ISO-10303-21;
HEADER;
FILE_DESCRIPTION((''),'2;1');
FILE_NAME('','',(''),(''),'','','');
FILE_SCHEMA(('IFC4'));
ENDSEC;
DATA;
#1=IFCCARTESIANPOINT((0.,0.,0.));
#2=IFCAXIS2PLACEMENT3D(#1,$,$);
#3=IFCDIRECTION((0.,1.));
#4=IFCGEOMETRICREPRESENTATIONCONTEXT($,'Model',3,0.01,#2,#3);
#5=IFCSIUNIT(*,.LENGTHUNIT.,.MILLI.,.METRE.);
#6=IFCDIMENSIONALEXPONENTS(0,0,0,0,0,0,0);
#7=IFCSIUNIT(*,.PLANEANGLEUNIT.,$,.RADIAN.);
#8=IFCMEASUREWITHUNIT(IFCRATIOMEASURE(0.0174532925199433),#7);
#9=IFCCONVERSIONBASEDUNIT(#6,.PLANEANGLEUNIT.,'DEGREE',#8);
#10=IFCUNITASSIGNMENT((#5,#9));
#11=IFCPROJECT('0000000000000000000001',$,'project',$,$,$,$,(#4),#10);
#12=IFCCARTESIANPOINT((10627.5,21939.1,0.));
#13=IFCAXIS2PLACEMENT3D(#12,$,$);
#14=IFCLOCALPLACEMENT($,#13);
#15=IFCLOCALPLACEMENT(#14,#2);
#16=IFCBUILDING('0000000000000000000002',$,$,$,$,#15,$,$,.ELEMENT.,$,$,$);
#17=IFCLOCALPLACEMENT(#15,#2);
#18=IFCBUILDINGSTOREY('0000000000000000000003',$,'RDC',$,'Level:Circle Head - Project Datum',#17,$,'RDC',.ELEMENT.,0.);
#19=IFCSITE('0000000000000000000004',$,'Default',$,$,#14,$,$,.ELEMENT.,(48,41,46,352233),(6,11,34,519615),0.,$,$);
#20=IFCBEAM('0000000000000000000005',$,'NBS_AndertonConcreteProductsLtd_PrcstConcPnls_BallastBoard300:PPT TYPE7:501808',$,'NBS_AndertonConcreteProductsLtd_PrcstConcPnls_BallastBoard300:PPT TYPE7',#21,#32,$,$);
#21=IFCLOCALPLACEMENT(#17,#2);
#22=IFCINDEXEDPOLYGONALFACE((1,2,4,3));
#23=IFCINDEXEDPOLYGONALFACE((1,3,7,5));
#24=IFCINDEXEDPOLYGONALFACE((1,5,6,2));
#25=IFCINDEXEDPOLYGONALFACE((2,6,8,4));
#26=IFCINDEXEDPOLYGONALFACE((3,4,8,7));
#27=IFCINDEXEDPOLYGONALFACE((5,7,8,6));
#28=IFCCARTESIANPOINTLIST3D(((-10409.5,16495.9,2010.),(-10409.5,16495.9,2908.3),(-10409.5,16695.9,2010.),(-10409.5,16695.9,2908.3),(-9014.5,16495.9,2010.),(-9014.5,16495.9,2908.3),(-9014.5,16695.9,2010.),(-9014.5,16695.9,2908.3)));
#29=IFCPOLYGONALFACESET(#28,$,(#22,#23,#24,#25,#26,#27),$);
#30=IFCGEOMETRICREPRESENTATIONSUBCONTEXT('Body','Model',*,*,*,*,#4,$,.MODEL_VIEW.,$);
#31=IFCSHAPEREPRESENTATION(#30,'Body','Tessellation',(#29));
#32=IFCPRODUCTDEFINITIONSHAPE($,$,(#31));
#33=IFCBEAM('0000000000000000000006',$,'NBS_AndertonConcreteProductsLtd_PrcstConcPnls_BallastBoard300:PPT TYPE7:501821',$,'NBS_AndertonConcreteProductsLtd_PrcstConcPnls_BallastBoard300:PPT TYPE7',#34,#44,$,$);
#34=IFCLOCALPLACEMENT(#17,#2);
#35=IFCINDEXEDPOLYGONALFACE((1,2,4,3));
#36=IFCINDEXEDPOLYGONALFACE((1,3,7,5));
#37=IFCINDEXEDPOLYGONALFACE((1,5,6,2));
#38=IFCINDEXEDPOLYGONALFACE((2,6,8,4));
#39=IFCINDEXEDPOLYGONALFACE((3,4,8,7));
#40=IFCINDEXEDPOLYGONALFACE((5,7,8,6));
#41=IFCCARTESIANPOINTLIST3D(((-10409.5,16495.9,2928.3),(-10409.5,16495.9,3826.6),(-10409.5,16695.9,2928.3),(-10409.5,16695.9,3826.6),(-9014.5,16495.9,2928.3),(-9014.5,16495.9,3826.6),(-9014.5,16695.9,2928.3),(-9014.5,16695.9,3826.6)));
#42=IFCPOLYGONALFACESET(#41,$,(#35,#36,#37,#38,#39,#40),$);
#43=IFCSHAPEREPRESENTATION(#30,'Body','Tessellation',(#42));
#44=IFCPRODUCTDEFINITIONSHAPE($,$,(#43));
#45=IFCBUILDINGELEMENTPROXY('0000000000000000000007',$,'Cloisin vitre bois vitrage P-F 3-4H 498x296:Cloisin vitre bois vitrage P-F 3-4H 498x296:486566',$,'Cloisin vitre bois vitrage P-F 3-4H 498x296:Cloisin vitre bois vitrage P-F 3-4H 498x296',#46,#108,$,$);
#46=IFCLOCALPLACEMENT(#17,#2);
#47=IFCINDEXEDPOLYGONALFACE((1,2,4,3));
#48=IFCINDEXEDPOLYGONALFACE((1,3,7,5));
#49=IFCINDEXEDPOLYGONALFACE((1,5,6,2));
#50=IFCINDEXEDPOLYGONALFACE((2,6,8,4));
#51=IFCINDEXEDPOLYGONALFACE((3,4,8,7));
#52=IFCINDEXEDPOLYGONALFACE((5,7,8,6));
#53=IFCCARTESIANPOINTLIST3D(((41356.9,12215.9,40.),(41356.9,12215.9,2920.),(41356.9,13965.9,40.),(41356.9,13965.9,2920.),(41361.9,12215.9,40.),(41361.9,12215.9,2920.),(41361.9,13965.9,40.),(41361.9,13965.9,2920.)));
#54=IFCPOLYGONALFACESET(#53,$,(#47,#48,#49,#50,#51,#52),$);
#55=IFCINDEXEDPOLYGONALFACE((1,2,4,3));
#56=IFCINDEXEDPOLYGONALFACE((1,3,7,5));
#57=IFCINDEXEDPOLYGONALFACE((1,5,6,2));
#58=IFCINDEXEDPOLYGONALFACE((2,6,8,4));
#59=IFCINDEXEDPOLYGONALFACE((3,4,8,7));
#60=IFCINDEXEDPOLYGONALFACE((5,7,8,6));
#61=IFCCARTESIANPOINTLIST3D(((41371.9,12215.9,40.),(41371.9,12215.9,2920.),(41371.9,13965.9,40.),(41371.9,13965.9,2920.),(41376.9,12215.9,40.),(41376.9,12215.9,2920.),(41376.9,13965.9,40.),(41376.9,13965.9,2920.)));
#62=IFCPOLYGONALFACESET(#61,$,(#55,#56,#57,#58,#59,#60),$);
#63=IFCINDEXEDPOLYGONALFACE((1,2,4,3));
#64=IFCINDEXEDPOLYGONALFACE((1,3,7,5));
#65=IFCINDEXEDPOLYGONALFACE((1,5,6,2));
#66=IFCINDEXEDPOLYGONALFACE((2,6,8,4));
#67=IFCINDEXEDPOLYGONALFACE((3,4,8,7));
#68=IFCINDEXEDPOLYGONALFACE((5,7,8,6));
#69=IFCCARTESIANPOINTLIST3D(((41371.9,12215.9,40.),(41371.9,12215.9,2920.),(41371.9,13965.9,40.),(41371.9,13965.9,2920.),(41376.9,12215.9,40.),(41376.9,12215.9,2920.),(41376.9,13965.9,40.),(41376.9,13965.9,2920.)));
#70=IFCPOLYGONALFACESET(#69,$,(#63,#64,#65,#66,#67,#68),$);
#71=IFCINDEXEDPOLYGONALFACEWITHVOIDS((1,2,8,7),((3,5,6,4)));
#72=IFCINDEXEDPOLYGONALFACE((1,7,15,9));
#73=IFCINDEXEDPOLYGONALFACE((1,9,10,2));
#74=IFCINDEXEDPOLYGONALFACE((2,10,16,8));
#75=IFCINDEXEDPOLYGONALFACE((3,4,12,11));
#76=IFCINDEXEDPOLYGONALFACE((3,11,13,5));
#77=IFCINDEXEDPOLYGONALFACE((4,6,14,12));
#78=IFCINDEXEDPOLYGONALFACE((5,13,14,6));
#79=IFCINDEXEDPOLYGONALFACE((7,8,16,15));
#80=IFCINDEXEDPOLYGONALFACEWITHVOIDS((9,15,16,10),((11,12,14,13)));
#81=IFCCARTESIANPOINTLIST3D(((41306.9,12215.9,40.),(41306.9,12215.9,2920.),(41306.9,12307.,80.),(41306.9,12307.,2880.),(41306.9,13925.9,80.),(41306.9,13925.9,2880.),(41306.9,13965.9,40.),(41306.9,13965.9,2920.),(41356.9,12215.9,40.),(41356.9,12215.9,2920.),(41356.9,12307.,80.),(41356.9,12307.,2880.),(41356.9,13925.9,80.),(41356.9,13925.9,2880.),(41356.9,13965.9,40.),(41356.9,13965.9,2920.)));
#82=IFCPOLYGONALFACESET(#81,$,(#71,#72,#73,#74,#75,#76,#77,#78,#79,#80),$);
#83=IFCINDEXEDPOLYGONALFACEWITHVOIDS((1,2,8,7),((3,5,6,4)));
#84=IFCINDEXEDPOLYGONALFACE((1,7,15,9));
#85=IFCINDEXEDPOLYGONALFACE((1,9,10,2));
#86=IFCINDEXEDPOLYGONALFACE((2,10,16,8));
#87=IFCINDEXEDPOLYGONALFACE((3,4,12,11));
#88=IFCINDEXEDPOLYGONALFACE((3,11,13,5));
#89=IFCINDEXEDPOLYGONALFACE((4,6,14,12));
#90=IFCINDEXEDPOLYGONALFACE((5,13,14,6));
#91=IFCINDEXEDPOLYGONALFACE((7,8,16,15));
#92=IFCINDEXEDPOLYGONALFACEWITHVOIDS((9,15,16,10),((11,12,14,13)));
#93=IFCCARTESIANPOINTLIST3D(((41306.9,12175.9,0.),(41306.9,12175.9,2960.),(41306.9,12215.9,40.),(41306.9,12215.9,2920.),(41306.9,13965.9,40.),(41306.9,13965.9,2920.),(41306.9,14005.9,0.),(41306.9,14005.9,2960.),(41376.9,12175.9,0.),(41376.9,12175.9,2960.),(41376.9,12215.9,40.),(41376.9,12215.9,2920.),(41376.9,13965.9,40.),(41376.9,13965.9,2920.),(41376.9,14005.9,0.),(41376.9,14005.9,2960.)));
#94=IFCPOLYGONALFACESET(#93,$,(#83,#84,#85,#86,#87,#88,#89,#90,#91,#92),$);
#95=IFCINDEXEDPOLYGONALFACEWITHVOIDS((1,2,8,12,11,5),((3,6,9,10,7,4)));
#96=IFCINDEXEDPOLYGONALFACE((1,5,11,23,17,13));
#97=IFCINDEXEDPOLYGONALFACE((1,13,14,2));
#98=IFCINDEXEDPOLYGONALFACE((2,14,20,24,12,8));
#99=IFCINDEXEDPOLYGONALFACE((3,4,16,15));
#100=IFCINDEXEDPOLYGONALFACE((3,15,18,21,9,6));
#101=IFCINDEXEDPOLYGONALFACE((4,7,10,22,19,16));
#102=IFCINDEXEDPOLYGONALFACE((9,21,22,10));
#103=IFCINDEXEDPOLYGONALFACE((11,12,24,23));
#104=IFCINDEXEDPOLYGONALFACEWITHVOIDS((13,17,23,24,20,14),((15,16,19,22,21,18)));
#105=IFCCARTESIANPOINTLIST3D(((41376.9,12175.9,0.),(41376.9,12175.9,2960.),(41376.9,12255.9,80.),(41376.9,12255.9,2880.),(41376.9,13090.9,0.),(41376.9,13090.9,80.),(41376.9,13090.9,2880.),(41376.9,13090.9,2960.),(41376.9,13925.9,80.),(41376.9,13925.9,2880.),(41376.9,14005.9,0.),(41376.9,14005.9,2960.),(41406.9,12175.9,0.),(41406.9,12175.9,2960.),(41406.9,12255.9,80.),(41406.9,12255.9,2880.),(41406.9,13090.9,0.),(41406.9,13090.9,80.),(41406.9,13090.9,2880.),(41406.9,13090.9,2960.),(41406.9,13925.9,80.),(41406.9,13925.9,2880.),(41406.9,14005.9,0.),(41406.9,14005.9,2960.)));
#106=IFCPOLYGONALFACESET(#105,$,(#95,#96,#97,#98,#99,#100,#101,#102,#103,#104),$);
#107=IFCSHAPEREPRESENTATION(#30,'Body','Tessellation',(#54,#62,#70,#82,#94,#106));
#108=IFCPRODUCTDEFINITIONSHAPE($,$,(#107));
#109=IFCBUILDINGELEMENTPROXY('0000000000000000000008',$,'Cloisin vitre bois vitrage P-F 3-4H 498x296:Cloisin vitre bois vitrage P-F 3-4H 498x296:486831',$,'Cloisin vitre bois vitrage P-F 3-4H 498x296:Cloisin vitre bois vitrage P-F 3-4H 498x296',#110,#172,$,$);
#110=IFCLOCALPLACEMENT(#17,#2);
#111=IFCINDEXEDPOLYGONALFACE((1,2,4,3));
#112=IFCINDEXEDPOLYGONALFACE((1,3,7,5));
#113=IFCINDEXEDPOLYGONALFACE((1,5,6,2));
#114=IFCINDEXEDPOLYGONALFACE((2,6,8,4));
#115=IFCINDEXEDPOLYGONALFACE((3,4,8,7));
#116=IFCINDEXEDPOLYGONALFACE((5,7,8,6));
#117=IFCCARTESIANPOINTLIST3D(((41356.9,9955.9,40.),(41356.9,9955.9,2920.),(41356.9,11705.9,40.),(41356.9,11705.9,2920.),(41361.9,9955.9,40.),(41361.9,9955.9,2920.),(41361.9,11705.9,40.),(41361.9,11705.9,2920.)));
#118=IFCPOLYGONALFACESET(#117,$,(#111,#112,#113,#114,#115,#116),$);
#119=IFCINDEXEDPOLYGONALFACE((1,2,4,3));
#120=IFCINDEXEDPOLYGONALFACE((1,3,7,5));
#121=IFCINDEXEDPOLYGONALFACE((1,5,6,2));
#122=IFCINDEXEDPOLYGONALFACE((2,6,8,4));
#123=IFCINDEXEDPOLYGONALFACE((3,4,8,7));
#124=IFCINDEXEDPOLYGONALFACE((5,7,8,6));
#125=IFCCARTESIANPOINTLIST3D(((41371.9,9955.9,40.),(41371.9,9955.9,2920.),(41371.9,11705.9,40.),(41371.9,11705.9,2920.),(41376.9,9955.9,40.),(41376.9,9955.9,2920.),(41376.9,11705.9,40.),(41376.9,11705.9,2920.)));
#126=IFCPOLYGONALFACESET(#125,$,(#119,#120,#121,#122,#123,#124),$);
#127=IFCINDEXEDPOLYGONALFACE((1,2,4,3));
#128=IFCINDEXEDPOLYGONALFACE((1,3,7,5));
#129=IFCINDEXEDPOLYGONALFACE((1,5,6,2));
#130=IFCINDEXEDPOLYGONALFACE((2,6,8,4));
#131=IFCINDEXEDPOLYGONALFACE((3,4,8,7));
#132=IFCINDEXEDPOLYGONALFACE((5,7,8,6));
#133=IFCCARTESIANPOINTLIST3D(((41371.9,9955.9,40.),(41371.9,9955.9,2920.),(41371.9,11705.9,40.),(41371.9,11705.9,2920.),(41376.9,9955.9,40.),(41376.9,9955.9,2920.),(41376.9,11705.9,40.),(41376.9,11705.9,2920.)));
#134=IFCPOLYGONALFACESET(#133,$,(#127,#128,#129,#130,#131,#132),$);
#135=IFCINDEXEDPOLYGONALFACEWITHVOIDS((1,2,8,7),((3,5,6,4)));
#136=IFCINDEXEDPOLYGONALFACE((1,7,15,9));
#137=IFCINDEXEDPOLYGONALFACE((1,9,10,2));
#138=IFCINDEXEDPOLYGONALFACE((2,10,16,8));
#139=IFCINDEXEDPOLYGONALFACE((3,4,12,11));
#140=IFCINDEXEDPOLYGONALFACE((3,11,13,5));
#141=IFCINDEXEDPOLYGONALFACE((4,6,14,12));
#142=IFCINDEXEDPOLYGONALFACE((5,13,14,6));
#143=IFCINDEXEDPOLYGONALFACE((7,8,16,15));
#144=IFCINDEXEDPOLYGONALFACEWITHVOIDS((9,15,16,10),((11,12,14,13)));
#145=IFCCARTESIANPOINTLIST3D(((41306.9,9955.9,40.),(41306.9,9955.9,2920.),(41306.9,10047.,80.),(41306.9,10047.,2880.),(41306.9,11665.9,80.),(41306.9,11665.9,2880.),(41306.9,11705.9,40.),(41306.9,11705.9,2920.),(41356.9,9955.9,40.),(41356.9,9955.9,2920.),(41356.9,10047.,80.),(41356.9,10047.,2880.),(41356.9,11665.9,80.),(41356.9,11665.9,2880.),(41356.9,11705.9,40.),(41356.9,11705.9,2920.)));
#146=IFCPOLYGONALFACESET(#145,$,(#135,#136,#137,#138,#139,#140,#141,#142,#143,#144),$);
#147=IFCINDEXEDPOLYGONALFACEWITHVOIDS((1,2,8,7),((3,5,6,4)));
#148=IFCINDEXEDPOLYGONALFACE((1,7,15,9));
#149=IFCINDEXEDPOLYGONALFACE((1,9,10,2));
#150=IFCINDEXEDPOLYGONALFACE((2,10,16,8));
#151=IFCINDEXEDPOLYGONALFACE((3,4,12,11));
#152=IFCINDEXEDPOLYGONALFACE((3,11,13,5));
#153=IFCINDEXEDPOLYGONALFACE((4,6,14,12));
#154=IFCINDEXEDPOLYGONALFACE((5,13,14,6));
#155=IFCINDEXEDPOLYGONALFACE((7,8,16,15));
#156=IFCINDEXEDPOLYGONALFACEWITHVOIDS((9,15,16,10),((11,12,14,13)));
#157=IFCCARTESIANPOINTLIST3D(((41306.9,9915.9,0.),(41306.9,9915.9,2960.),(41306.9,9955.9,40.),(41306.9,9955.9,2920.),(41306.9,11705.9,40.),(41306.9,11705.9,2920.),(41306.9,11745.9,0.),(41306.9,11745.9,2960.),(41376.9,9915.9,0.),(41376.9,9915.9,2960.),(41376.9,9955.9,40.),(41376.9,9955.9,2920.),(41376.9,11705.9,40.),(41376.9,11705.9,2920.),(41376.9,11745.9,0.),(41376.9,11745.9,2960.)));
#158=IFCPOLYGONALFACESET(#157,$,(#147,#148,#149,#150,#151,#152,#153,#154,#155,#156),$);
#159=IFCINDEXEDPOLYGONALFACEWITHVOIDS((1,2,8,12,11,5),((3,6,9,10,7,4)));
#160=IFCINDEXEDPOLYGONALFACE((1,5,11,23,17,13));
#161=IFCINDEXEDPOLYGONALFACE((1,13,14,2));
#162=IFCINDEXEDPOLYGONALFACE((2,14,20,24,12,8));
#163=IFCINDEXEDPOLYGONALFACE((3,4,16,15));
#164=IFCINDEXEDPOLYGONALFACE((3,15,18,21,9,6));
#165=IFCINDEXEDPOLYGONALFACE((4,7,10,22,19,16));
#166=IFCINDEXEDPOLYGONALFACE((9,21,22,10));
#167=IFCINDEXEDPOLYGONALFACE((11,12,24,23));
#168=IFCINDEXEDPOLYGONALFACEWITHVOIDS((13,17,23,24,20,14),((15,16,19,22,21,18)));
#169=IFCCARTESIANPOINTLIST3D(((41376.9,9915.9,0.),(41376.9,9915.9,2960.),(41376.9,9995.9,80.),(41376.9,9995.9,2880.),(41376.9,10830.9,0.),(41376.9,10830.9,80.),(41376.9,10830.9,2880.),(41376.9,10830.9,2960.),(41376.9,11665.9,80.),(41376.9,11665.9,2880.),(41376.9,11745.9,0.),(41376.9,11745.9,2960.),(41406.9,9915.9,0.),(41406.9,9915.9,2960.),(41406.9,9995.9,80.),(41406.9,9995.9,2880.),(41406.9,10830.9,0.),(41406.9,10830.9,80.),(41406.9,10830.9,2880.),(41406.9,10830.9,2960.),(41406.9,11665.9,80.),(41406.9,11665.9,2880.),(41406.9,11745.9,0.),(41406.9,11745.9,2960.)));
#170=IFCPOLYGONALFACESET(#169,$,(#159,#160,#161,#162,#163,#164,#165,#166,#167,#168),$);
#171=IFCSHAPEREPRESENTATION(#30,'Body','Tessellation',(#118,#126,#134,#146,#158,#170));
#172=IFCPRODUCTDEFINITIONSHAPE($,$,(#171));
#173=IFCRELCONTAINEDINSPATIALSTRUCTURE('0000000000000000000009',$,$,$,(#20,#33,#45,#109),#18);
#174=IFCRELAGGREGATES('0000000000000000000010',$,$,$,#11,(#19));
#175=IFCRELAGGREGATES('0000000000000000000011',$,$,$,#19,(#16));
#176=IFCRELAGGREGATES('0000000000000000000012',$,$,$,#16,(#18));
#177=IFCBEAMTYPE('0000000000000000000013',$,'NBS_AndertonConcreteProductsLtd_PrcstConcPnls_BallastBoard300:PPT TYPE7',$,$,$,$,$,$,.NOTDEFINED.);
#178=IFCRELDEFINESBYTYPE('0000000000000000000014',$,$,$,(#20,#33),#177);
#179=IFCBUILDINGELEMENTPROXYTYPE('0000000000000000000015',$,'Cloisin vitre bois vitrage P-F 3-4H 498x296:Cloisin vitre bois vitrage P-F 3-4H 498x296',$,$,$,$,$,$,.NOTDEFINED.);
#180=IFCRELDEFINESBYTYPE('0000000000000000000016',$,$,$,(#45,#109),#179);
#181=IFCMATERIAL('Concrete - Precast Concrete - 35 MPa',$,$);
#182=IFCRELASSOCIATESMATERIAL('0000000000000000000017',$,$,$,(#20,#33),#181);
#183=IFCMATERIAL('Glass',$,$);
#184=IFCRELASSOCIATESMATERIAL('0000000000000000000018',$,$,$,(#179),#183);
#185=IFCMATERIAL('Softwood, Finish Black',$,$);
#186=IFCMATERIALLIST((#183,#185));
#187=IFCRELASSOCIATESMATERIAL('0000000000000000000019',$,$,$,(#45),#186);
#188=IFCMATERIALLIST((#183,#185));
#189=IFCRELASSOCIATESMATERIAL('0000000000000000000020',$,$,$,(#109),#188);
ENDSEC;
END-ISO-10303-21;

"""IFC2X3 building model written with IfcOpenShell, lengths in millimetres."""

from ifc_helpers import new_model, entity, si_unit, converted_unit, direction, frame, frame_2d, origin, place, context, subcontext, project, spatial, polyline, rectangle, outline, extrude, source, transform, mapped, material, material_list, type_object, type_shapes, element, save


model = new_model("IFC2X3")

# Units and contexts
model_context = context("Model", 3, precision=0.01, world=origin(), true_north=direction((0.0, 1.0)))
body_context = subcontext(model_context, "Body", "Model", "MODEL_VIEW")
ifc_project = project(units=[si_unit("LENGTHUNIT", "METRE", prefix="MILLI"), converted_unit("PLANEANGLEUNIT", "DEGREE", entity("IfcRatioMeasure", 0.0174532925199433), si_unit("PLANEANGLEUNIT", "RADIAN"), dimensions=[0, 0, 0, 0, 0, 0, 0])], contexts=[model_context])

# Site, building, storey
site_placement = place(None, frame((10627.5, 21939.1, 0.0)))
site = spatial("IfcSite", under=ifc_project, at=site_placement, Name="Default", CompositionType="ELEMENT", RefLatitude=(48, 41, 46, 352233), RefLongitude=(6, 11, 34, 519615), RefElevation=0.0)
building_placement = place(site_placement, origin())
building = spatial("IfcBuilding", under=site, at=building_placement, CompositionType="ELEMENT")
storey_placement = place(building_placement, origin())
storey = spatial("IfcBuildingStorey", under=building, at=storey_placement, Name="RDC", ObjectType="Level:Circle Head - Project Datum", LongName="RDC", CompositionType="ELEMENT", Elevation=0.0)

# Beams
ifc_material_1 = material(Name="Concrete - Precast Concrete - 35 MPa")
beam_type = type_object("IfcBeamType", Name="NBS_AndertonConcreteProductsLtd_PrcstConcPnls_BallastBoard300:PPT TYPE7", PredefinedType="NOTDEFINED")
beam_1_placement = place(storey_placement, origin())
element("IfcBeam", 1, at=beam_1_placement, inside=storey, type_object=beam_type, material=ifc_material_1, Name="NBS_AndertonConcreteProductsLtd_PrcstConcPnls_BallastBoard300:PPT TYPE7:501808", ObjectType="NBS_AndertonConcreteProductsLtd_PrcstConcPnls_BallastBoard300:PPT TYPE7", context=body_context, shape_type="SweptSolid", body=[
    extrude(rectangle(XDim=898.3, YDim=200.0, at=frame_2d((0.0, 0.0), x_axis=(0.0, 1.0))), frame((-10409.5, 16595.9, 2459.1), z_axis=(1.0, 0.0, 0.0), x_axis=(0.0, 1.0, 0.0)), (0.0, 0.0, 1.0), 1395.0),
])
beam_2_placement = place(storey_placement, origin())
element("IfcBeam", 2, at=beam_2_placement, inside=storey, type_object=beam_type, material=ifc_material_1, Name="NBS_AndertonConcreteProductsLtd_PrcstConcPnls_BallastBoard300:PPT TYPE7:501821", ObjectType="NBS_AndertonConcreteProductsLtd_PrcstConcPnls_BallastBoard300:PPT TYPE7", context=body_context, shape_type="SweptSolid", body=[
    extrude(rectangle(XDim=898.3, YDim=200.0, at=frame_2d((0.0, 0.0), x_axis=(0.0, 1.0))), frame((-10409.5, 16595.9, 3377.4), z_axis=(1.0, 0.0, 0.0), x_axis=(0.0, 1.0, 0.0)), (0.0, 0.0, 1.0), 1395.0),
])

# Building element proxies
ifc_material_2 = material(Name="Glass")
ifc_material_3 = material(Name="Softwood, Finish Black")
ifc_material_list_1 = material_list([ifc_material_2, ifc_material_3])
building_element_proxy_type_1 = type_object("IfcBuildingElementProxyType", Name="Cloisin vitre bois vitrage P-F 3-4H 498x296:Cloisin vitre bois vitrage P-F 3-4H 498x296", PredefinedType="NOTDEFINED", material=ifc_material_2)
shared_shape_1 = source(origin(), body_context, "Body", "SweptSolid", [
    extrude(rectangle(XDim=5.0, YDim=1750.0, at=frame_2d((0.0, 0.0), x_axis=(1.0, 0.0))), frame((0.0, -47.5, 40.0), z_axis=(0.0, 0.0, 1.0), x_axis=(0.0, 1.0, 0.0)), (0.0, 0.0, 1.0), 2880.0),
    extrude(rectangle(XDim=5.0, YDim=1750.0, at=frame_2d((0.0, 0.0), x_axis=(1.0, 0.0))), frame((0.0, -32.5, 40.0), z_axis=(0.0, 0.0, 1.0), x_axis=(0.0, 1.0, 0.0)), (0.0, 0.0, 1.0), 2880.0),
    extrude(rectangle(XDim=5.0, YDim=1750.0, at=frame_2d((0.0, 0.0), x_axis=(1.0, 0.0))), frame((0.0, -32.5, 40.0), z_axis=(0.0, 0.0, 1.0), x_axis=(0.0, 1.0, 0.0)), (0.0, 0.0, 1.0), 2880.0),
    extrude(outline(polyline([(-1440.0, -875.0), (1440.0, -875.0), (1440.0, 875.0), (-1440.0, 875.0), (-1440.0, -875.0)]), holes=[polyline([(1400.0, 835.0), (1400.0, -783.9), (-1400.0, -783.9), (-1400.0, 835.0), (1400.0, 835.0)])]), frame((0.0, -100.0, 1480.0), z_axis=(0.0, 1.0, 0.0), x_axis=(0.0, 0.0, -1.0)), (0.0, 0.0, 1.0), 50.0),
    extrude(outline(polyline([(-1480.0, -915.0), (1480.0, -915.0), (1480.0, 915.0), (-1480.0, 915.0), (-1480.0, -915.0)]), holes=[polyline([(-1440.0, -875.0), (-1440.0, 875.0), (1440.0, 875.0), (1440.0, -875.0), (-1440.0, -875.0)])]), frame((0.0, -100.0, 1480.0), z_axis=(0.0, 1.0, 0.0), x_axis=(0.0, 0.0, -1.0)), (0.0, 0.0, 1.0), 70.0),
    extrude(outline(polyline([(-1480.0, -915.0), (1480.0, -915.0), (1480.0, 0.0), (1480.0, 915.0), (-1480.0, 915.0), (-1480.0, 0.0), (-1480.0, -915.0)]), holes=[polyline([(1400.0, 0.0), (1400.0, -835.0), (-1400.0, -835.0), (-1400.0, 0.0), (-1400.0, 835.0), (1400.0, 835.0), (1400.0, 0.0)])]), frame((0.0, -30.0, 1480.0), z_axis=(0.0, 1.0, 0.0), x_axis=(0.0, 0.0, 1.0)), (0.0, 0.0, 1.0), 30.0),
])
type_shapes(building_element_proxy_type_1, [shared_shape_1])
proxy_1_placement = place(storey_placement, frame((41406.9, 13090.9, 0.0), z_axis=(0.0, 0.0, 1.0), x_axis=(0.0, -1.0, 0.0)))
element("IfcBuildingElementProxy", 3, at=proxy_1_placement, inside=storey, type_object=building_element_proxy_type_1, material=ifc_material_list_1, Name="Cloisin vitre bois vitrage P-F 3-4H 498x296:Cloisin vitre bois vitrage P-F 3-4H 498x296:486566", ObjectType="Cloisin vitre bois vitrage P-F 3-4H 498x296:Cloisin vitre bois vitrage P-F 3-4H 498x296", context=body_context, shape_type="MappedRepresentation", body=[
    mapped(shared_shape_1, transform((0.0, 0.0, 0.0), scale=1.0)),
])
ifc_material_list_2 = material_list([ifc_material_2, ifc_material_3])
proxy_2_placement = place(storey_placement, frame((41406.9, 10830.9, 0.0), z_axis=(0.0, 0.0, 1.0), x_axis=(0.0, -1.0, 0.0)))
element("IfcBuildingElementProxy", 4, at=proxy_2_placement, inside=storey, type_object=building_element_proxy_type_1, material=ifc_material_list_2, Name="Cloisin vitre bois vitrage P-F 3-4H 498x296:Cloisin vitre bois vitrage P-F 3-4H 498x296:486831", ObjectType="Cloisin vitre bois vitrage P-F 3-4H 498x296:Cloisin vitre bois vitrage P-F 3-4H 498x296", context=body_context, shape_type="MappedRepresentation", body=[
    mapped(shared_shape_1, transform((0.0, 0.0, 0.0), scale=1.0)),
])

save(model, "model.ifc")
